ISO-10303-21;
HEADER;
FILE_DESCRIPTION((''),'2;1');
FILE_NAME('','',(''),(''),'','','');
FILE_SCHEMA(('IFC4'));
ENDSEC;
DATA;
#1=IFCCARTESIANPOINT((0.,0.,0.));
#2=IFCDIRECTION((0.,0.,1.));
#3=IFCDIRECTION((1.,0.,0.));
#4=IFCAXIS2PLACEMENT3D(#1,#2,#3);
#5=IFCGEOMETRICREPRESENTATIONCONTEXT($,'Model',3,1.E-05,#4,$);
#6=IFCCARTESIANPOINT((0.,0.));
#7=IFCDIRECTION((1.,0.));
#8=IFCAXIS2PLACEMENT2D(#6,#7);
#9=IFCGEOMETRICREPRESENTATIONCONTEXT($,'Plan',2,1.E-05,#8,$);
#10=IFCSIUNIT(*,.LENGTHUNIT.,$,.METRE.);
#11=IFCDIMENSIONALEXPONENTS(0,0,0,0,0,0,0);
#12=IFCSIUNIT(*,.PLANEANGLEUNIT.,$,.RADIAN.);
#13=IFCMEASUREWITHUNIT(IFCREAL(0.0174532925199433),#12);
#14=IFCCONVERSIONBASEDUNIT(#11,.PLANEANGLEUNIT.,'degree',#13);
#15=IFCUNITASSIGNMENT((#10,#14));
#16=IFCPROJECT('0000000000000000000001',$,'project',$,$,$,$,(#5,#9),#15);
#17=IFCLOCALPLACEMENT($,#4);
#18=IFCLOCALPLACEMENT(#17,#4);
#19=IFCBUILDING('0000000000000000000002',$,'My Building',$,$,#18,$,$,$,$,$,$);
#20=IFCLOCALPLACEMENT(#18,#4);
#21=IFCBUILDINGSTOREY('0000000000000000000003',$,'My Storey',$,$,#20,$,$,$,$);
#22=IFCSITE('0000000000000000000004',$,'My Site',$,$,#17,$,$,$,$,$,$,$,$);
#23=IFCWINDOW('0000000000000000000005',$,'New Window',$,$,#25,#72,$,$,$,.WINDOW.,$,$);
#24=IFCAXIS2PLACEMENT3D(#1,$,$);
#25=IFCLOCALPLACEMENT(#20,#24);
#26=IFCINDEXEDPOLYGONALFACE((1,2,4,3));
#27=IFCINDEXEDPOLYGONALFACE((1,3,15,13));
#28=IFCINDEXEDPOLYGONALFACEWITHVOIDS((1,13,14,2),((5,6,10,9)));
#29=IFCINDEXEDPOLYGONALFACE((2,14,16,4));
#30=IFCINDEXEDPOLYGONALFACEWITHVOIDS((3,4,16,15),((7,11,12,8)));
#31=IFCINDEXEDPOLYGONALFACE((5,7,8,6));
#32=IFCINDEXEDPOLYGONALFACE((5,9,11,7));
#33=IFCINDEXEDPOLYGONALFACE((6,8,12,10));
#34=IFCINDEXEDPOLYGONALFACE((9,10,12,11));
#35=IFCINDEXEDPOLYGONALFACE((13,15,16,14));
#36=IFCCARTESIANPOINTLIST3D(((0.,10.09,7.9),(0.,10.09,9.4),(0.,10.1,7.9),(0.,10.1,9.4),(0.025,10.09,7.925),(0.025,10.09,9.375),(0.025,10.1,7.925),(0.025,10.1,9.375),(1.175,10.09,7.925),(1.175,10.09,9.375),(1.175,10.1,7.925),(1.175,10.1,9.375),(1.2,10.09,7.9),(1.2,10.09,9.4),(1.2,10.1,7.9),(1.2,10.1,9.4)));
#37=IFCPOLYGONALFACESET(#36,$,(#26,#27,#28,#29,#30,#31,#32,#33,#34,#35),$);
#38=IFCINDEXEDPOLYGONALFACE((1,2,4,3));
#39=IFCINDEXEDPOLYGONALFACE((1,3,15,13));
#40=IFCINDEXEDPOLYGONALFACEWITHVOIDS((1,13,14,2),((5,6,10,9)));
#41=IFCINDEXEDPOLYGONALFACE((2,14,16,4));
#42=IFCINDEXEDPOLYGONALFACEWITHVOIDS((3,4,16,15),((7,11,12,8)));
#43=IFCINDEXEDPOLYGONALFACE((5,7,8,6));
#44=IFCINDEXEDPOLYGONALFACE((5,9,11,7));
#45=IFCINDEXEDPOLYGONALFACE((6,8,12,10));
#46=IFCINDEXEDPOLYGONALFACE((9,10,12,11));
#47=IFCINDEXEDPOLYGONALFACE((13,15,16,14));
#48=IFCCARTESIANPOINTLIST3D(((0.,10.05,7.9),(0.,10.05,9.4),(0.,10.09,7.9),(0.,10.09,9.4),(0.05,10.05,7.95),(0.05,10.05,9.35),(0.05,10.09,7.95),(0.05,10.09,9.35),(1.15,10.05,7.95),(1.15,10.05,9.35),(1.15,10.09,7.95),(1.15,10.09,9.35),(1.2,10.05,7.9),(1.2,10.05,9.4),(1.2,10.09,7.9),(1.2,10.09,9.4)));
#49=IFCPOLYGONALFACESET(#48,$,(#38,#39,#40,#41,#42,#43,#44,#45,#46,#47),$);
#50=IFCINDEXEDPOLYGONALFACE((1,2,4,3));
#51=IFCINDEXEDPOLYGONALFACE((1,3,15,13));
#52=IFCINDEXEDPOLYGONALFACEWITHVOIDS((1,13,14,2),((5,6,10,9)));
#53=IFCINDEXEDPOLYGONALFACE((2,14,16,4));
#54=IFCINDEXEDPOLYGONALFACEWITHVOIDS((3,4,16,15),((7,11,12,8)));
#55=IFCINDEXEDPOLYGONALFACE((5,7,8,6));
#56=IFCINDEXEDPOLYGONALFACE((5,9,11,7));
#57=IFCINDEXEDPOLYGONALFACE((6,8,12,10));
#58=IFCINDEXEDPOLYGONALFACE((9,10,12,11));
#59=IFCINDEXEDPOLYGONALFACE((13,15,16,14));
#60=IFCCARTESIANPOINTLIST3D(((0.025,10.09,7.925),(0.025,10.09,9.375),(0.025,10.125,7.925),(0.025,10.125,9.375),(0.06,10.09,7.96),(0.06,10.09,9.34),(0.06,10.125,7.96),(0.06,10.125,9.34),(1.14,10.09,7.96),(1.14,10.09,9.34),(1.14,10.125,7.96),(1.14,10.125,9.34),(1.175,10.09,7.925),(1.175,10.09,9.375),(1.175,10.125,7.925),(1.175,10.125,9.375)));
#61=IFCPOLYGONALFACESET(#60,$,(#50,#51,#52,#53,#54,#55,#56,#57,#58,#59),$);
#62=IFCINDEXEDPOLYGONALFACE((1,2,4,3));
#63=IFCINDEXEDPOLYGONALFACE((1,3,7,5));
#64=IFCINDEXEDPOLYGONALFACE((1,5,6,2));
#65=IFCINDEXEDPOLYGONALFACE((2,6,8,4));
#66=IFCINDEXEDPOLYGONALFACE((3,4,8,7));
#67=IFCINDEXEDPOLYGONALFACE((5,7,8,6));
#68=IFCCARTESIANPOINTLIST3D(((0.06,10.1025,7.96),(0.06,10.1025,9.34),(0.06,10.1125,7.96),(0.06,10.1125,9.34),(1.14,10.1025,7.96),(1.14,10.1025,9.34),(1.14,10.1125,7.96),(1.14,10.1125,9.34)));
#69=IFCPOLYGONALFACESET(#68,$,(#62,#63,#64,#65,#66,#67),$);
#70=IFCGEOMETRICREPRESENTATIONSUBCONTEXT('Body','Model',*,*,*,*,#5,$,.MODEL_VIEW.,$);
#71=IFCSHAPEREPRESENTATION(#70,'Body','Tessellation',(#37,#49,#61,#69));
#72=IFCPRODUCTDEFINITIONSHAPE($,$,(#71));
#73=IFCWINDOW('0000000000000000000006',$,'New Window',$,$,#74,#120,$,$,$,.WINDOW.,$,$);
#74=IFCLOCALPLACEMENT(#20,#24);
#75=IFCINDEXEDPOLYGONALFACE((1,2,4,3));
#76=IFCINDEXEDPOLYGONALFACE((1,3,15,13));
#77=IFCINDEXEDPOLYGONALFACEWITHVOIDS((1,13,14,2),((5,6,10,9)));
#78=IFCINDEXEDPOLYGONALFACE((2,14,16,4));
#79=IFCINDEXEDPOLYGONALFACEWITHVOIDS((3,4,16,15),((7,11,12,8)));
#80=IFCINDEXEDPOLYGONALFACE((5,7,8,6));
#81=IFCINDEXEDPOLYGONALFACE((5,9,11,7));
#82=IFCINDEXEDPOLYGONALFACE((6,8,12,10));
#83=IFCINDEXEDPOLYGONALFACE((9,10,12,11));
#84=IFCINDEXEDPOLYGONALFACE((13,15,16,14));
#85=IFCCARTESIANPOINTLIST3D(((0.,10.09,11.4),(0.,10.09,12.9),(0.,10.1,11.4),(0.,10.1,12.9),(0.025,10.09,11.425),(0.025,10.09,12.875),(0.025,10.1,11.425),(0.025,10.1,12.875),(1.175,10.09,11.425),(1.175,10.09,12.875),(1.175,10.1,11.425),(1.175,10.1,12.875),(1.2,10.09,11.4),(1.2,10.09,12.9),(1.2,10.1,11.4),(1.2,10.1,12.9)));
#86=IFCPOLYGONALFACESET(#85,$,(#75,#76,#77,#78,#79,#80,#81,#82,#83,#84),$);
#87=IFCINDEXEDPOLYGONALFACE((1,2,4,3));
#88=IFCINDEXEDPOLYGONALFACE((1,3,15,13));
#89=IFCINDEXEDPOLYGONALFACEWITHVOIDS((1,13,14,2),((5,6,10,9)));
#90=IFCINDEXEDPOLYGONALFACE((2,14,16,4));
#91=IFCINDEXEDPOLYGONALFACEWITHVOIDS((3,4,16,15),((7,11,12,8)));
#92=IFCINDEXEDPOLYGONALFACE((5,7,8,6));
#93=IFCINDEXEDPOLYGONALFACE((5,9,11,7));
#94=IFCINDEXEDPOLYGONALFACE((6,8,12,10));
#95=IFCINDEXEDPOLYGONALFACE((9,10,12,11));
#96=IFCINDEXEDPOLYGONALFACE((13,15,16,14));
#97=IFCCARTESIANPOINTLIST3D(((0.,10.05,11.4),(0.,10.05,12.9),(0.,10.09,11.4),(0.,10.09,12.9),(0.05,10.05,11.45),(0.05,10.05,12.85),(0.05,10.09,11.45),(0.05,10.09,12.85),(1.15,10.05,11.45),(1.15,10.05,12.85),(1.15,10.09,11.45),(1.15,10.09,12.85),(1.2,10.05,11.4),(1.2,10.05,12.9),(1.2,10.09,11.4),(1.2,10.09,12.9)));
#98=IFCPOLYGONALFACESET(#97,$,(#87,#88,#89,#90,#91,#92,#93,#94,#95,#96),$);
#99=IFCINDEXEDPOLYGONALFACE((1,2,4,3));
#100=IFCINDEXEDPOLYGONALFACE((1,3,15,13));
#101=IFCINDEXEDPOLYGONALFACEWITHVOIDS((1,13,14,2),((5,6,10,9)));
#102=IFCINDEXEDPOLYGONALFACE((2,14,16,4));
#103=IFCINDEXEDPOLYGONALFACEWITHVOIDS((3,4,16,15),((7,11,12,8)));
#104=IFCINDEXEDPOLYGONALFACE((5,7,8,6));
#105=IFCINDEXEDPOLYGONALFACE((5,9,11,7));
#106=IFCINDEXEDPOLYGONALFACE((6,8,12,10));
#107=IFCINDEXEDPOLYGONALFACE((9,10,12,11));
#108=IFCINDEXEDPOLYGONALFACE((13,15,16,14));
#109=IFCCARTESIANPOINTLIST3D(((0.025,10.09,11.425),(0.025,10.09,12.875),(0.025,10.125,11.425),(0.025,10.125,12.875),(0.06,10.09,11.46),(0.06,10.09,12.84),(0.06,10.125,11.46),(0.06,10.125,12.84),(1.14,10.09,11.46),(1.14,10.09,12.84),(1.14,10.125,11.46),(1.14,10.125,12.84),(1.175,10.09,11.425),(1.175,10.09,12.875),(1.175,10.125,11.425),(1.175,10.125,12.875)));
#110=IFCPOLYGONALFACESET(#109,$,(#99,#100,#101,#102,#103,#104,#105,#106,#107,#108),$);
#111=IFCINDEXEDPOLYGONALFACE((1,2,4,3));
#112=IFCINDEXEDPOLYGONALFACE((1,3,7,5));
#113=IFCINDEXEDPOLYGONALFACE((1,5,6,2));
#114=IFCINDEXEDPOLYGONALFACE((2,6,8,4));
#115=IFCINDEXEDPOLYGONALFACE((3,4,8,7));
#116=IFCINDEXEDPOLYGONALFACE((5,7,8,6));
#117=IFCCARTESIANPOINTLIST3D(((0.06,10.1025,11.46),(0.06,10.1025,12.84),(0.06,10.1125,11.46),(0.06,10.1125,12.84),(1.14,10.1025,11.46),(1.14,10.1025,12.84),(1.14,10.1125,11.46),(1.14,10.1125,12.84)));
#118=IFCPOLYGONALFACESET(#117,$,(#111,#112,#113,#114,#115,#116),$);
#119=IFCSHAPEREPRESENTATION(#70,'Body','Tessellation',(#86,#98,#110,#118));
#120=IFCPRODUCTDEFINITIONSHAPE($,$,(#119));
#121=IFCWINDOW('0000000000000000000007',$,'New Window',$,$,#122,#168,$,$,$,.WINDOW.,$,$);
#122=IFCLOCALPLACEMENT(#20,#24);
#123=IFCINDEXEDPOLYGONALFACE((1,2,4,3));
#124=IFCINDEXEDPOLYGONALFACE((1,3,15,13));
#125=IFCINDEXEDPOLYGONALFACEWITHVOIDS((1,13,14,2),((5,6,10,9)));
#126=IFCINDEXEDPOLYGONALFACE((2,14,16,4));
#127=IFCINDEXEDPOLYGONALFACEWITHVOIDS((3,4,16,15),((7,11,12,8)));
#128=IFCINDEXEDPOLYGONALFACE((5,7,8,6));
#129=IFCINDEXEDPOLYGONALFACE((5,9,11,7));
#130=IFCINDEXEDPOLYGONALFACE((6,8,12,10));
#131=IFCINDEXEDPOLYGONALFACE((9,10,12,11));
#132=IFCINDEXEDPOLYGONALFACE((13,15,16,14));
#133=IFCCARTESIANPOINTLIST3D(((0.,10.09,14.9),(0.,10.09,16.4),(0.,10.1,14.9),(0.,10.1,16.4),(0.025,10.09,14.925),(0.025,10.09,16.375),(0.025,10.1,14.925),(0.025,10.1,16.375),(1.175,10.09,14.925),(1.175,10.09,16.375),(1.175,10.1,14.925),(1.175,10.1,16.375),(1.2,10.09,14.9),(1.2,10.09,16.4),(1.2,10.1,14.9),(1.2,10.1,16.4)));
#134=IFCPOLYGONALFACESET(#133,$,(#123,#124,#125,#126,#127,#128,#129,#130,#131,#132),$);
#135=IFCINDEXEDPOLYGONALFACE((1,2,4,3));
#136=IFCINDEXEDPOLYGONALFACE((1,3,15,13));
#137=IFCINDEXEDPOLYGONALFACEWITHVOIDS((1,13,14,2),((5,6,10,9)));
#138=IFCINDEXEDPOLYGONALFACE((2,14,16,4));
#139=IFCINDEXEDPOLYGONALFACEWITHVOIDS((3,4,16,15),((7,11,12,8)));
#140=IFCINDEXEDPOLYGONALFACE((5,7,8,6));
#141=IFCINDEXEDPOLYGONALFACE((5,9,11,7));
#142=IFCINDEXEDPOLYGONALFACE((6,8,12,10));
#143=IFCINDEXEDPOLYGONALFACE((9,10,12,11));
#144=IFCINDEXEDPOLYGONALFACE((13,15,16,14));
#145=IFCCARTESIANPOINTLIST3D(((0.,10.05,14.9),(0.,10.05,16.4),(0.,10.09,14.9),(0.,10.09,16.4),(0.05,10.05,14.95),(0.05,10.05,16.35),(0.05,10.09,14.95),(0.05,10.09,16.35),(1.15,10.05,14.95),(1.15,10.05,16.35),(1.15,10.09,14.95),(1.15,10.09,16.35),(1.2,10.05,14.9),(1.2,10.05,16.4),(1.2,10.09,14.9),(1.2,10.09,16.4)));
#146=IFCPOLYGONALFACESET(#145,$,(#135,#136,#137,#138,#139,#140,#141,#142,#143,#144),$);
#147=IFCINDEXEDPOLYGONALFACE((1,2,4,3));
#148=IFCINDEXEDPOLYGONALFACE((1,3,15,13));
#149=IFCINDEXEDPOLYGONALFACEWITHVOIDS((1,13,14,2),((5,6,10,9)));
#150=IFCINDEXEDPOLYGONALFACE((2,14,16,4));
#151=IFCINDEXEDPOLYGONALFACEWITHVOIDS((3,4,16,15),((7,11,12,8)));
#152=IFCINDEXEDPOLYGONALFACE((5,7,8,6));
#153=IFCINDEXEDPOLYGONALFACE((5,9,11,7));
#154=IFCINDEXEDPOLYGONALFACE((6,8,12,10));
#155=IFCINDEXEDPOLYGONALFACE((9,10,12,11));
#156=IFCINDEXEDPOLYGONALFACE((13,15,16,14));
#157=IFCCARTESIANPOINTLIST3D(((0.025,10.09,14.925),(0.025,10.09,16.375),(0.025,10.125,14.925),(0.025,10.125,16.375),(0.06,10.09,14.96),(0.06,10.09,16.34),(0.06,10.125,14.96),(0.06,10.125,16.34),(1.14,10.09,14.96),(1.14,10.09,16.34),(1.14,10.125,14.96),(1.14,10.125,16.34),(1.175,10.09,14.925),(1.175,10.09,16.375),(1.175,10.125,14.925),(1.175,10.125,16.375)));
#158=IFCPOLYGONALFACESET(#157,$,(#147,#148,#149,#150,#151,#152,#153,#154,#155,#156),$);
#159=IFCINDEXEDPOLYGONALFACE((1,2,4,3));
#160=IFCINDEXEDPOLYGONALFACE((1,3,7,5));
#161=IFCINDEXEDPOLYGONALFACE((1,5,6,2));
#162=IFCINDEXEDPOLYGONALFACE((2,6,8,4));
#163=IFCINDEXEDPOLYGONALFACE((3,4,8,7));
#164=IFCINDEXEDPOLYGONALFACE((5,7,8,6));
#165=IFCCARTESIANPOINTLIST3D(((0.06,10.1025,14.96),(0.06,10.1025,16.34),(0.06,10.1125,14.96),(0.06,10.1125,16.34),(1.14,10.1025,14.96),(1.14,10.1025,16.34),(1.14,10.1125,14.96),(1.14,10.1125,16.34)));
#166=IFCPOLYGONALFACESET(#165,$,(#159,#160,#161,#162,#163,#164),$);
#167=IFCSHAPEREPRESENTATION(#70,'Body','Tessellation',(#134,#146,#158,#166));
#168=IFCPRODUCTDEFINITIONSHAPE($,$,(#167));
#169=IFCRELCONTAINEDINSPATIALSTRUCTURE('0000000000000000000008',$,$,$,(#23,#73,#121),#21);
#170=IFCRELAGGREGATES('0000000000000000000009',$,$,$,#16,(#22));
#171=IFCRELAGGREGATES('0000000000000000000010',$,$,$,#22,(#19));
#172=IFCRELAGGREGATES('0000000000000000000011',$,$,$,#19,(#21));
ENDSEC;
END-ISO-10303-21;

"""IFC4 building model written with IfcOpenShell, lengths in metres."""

from ifc_helpers import new_model, entity, si_unit, converted_unit, frame, origin_with_axes, origin_2d_with_axis, place, context, subcontext, project, spatial, line, indexed_curve, outline, extrude, element, save


model = new_model("IFC4")

# Units and contexts
model_context = context("Model", 3, precision=1e-05, world=origin_with_axes())
plan_context = context("Plan", 2, precision=1e-05, world=origin_2d_with_axis())
body_context = subcontext(model_context, "Body", "Model", "MODEL_VIEW")
ifc_project = project(units=[si_unit("LENGTHUNIT", "METRE"), converted_unit("PLANEANGLEUNIT", "degree", entity("IfcReal", 0.0174532925199433), si_unit("PLANEANGLEUNIT", "RADIAN"), dimensions=[0, 0, 0, 0, 0, 0, 0])], contexts=[model_context, plan_context])

# Site, building, storey
site_placement = place(None, origin_with_axes())
site = spatial("IfcSite", under=ifc_project, at=site_placement, Name="My Site")
building_placement = place(site_placement, origin_with_axes())
building = spatial("IfcBuilding", under=site, at=building_placement, Name="My Building")
storey_placement = place(building_placement, origin_with_axes())
storey = spatial("IfcBuildingStorey", under=building, at=storey_placement, Name="My Storey")

# Windows
for number, where, z_axis, x_axis, name in (
    (1, (0.0, 10.0, 7.9), (0.0, 0.0, 1.0), (1.0, 0.0, 0.0), "New Window"),
    (2, (0.0, 10.0, 11.4), (0.0, 0.0, 1.0), (1.0, 0.0, 0.0), "New Window"),
    (3, (0.0, 10.0, 14.9), (0.0, 0.0, 1.0), (1.0, 0.0, 0.0), "New Window"),
):
    element("IfcWindow", number, at=place(storey_placement, frame(where, z_axis=z_axis, x_axis=x_axis)), inside=storey, Name=name, PredefinedType="WINDOW", context=body_context, shape_type="SweptSolid", body=[
        extrude(outline(indexed_curve([(0.0, 0.0), (1.2, 0.0), (1.2, 1.5), (0.0, 1.5)], segments=[line(1, 2, 3, 4, 1)]), holes=[indexed_curve([(0.025, 0.025), (1.175, 0.025), (1.175, 1.475), (0.025, 1.475)], segments=[line(1, 2, 3, 4, 1)])]), frame((0.0, 0.09, 0.0), z_axis=(0.0, -1.0, 0.0), x_axis=(1.0, 0.0, 0.0)), (0.0, 0.0, -1.0), 0.01),
        extrude(outline(indexed_curve([(0.0, 0.0), (1.2, 0.0), (1.2, 1.5), (0.0, 1.5)], segments=[line(1, 2, 3, 4, 1)]), holes=[indexed_curve([(0.05, 0.05), (1.15, 0.05), (1.15, 1.45), (0.05, 1.45)], segments=[line(1, 2, 3, 4, 1)])]), frame((0.0, 0.05, 0.0), z_axis=(0.0, -1.0, 0.0), x_axis=(1.0, 0.0, 0.0)), (0.0, 0.0, -1.0), 0.04),
        extrude(outline(indexed_curve([(0.0, 0.0), (1.15, 0.0), (1.15, 1.45), (0.0, 1.45)], segments=[line(1, 2, 3, 4, 1)]), holes=[indexed_curve([(0.035, 0.035), (1.115, 0.035), (1.115, 1.415), (0.035, 1.415)], segments=[line(1, 2, 3, 4, 1)])]), frame((0.025, 0.09, 0.025), z_axis=(0.0, -1.0, 0.0), x_axis=(1.0, 0.0, 0.0)), (0.0, 0.0, -1.0), 0.035),
        extrude(outline(indexed_curve([(0.035, 0.035), (1.115, 0.035), (1.115, 1.415), (0.035, 1.415)], segments=[line(1, 2, 3, 4, 1)])), frame((0.025, 0.1025, 0.025), z_axis=(0.0, -1.0, 0.0), x_axis=(1.0, 0.0, 0.0)), (0.0, 0.0, -1.0), 0.01),
    ])

save(model, "model.ifc")
